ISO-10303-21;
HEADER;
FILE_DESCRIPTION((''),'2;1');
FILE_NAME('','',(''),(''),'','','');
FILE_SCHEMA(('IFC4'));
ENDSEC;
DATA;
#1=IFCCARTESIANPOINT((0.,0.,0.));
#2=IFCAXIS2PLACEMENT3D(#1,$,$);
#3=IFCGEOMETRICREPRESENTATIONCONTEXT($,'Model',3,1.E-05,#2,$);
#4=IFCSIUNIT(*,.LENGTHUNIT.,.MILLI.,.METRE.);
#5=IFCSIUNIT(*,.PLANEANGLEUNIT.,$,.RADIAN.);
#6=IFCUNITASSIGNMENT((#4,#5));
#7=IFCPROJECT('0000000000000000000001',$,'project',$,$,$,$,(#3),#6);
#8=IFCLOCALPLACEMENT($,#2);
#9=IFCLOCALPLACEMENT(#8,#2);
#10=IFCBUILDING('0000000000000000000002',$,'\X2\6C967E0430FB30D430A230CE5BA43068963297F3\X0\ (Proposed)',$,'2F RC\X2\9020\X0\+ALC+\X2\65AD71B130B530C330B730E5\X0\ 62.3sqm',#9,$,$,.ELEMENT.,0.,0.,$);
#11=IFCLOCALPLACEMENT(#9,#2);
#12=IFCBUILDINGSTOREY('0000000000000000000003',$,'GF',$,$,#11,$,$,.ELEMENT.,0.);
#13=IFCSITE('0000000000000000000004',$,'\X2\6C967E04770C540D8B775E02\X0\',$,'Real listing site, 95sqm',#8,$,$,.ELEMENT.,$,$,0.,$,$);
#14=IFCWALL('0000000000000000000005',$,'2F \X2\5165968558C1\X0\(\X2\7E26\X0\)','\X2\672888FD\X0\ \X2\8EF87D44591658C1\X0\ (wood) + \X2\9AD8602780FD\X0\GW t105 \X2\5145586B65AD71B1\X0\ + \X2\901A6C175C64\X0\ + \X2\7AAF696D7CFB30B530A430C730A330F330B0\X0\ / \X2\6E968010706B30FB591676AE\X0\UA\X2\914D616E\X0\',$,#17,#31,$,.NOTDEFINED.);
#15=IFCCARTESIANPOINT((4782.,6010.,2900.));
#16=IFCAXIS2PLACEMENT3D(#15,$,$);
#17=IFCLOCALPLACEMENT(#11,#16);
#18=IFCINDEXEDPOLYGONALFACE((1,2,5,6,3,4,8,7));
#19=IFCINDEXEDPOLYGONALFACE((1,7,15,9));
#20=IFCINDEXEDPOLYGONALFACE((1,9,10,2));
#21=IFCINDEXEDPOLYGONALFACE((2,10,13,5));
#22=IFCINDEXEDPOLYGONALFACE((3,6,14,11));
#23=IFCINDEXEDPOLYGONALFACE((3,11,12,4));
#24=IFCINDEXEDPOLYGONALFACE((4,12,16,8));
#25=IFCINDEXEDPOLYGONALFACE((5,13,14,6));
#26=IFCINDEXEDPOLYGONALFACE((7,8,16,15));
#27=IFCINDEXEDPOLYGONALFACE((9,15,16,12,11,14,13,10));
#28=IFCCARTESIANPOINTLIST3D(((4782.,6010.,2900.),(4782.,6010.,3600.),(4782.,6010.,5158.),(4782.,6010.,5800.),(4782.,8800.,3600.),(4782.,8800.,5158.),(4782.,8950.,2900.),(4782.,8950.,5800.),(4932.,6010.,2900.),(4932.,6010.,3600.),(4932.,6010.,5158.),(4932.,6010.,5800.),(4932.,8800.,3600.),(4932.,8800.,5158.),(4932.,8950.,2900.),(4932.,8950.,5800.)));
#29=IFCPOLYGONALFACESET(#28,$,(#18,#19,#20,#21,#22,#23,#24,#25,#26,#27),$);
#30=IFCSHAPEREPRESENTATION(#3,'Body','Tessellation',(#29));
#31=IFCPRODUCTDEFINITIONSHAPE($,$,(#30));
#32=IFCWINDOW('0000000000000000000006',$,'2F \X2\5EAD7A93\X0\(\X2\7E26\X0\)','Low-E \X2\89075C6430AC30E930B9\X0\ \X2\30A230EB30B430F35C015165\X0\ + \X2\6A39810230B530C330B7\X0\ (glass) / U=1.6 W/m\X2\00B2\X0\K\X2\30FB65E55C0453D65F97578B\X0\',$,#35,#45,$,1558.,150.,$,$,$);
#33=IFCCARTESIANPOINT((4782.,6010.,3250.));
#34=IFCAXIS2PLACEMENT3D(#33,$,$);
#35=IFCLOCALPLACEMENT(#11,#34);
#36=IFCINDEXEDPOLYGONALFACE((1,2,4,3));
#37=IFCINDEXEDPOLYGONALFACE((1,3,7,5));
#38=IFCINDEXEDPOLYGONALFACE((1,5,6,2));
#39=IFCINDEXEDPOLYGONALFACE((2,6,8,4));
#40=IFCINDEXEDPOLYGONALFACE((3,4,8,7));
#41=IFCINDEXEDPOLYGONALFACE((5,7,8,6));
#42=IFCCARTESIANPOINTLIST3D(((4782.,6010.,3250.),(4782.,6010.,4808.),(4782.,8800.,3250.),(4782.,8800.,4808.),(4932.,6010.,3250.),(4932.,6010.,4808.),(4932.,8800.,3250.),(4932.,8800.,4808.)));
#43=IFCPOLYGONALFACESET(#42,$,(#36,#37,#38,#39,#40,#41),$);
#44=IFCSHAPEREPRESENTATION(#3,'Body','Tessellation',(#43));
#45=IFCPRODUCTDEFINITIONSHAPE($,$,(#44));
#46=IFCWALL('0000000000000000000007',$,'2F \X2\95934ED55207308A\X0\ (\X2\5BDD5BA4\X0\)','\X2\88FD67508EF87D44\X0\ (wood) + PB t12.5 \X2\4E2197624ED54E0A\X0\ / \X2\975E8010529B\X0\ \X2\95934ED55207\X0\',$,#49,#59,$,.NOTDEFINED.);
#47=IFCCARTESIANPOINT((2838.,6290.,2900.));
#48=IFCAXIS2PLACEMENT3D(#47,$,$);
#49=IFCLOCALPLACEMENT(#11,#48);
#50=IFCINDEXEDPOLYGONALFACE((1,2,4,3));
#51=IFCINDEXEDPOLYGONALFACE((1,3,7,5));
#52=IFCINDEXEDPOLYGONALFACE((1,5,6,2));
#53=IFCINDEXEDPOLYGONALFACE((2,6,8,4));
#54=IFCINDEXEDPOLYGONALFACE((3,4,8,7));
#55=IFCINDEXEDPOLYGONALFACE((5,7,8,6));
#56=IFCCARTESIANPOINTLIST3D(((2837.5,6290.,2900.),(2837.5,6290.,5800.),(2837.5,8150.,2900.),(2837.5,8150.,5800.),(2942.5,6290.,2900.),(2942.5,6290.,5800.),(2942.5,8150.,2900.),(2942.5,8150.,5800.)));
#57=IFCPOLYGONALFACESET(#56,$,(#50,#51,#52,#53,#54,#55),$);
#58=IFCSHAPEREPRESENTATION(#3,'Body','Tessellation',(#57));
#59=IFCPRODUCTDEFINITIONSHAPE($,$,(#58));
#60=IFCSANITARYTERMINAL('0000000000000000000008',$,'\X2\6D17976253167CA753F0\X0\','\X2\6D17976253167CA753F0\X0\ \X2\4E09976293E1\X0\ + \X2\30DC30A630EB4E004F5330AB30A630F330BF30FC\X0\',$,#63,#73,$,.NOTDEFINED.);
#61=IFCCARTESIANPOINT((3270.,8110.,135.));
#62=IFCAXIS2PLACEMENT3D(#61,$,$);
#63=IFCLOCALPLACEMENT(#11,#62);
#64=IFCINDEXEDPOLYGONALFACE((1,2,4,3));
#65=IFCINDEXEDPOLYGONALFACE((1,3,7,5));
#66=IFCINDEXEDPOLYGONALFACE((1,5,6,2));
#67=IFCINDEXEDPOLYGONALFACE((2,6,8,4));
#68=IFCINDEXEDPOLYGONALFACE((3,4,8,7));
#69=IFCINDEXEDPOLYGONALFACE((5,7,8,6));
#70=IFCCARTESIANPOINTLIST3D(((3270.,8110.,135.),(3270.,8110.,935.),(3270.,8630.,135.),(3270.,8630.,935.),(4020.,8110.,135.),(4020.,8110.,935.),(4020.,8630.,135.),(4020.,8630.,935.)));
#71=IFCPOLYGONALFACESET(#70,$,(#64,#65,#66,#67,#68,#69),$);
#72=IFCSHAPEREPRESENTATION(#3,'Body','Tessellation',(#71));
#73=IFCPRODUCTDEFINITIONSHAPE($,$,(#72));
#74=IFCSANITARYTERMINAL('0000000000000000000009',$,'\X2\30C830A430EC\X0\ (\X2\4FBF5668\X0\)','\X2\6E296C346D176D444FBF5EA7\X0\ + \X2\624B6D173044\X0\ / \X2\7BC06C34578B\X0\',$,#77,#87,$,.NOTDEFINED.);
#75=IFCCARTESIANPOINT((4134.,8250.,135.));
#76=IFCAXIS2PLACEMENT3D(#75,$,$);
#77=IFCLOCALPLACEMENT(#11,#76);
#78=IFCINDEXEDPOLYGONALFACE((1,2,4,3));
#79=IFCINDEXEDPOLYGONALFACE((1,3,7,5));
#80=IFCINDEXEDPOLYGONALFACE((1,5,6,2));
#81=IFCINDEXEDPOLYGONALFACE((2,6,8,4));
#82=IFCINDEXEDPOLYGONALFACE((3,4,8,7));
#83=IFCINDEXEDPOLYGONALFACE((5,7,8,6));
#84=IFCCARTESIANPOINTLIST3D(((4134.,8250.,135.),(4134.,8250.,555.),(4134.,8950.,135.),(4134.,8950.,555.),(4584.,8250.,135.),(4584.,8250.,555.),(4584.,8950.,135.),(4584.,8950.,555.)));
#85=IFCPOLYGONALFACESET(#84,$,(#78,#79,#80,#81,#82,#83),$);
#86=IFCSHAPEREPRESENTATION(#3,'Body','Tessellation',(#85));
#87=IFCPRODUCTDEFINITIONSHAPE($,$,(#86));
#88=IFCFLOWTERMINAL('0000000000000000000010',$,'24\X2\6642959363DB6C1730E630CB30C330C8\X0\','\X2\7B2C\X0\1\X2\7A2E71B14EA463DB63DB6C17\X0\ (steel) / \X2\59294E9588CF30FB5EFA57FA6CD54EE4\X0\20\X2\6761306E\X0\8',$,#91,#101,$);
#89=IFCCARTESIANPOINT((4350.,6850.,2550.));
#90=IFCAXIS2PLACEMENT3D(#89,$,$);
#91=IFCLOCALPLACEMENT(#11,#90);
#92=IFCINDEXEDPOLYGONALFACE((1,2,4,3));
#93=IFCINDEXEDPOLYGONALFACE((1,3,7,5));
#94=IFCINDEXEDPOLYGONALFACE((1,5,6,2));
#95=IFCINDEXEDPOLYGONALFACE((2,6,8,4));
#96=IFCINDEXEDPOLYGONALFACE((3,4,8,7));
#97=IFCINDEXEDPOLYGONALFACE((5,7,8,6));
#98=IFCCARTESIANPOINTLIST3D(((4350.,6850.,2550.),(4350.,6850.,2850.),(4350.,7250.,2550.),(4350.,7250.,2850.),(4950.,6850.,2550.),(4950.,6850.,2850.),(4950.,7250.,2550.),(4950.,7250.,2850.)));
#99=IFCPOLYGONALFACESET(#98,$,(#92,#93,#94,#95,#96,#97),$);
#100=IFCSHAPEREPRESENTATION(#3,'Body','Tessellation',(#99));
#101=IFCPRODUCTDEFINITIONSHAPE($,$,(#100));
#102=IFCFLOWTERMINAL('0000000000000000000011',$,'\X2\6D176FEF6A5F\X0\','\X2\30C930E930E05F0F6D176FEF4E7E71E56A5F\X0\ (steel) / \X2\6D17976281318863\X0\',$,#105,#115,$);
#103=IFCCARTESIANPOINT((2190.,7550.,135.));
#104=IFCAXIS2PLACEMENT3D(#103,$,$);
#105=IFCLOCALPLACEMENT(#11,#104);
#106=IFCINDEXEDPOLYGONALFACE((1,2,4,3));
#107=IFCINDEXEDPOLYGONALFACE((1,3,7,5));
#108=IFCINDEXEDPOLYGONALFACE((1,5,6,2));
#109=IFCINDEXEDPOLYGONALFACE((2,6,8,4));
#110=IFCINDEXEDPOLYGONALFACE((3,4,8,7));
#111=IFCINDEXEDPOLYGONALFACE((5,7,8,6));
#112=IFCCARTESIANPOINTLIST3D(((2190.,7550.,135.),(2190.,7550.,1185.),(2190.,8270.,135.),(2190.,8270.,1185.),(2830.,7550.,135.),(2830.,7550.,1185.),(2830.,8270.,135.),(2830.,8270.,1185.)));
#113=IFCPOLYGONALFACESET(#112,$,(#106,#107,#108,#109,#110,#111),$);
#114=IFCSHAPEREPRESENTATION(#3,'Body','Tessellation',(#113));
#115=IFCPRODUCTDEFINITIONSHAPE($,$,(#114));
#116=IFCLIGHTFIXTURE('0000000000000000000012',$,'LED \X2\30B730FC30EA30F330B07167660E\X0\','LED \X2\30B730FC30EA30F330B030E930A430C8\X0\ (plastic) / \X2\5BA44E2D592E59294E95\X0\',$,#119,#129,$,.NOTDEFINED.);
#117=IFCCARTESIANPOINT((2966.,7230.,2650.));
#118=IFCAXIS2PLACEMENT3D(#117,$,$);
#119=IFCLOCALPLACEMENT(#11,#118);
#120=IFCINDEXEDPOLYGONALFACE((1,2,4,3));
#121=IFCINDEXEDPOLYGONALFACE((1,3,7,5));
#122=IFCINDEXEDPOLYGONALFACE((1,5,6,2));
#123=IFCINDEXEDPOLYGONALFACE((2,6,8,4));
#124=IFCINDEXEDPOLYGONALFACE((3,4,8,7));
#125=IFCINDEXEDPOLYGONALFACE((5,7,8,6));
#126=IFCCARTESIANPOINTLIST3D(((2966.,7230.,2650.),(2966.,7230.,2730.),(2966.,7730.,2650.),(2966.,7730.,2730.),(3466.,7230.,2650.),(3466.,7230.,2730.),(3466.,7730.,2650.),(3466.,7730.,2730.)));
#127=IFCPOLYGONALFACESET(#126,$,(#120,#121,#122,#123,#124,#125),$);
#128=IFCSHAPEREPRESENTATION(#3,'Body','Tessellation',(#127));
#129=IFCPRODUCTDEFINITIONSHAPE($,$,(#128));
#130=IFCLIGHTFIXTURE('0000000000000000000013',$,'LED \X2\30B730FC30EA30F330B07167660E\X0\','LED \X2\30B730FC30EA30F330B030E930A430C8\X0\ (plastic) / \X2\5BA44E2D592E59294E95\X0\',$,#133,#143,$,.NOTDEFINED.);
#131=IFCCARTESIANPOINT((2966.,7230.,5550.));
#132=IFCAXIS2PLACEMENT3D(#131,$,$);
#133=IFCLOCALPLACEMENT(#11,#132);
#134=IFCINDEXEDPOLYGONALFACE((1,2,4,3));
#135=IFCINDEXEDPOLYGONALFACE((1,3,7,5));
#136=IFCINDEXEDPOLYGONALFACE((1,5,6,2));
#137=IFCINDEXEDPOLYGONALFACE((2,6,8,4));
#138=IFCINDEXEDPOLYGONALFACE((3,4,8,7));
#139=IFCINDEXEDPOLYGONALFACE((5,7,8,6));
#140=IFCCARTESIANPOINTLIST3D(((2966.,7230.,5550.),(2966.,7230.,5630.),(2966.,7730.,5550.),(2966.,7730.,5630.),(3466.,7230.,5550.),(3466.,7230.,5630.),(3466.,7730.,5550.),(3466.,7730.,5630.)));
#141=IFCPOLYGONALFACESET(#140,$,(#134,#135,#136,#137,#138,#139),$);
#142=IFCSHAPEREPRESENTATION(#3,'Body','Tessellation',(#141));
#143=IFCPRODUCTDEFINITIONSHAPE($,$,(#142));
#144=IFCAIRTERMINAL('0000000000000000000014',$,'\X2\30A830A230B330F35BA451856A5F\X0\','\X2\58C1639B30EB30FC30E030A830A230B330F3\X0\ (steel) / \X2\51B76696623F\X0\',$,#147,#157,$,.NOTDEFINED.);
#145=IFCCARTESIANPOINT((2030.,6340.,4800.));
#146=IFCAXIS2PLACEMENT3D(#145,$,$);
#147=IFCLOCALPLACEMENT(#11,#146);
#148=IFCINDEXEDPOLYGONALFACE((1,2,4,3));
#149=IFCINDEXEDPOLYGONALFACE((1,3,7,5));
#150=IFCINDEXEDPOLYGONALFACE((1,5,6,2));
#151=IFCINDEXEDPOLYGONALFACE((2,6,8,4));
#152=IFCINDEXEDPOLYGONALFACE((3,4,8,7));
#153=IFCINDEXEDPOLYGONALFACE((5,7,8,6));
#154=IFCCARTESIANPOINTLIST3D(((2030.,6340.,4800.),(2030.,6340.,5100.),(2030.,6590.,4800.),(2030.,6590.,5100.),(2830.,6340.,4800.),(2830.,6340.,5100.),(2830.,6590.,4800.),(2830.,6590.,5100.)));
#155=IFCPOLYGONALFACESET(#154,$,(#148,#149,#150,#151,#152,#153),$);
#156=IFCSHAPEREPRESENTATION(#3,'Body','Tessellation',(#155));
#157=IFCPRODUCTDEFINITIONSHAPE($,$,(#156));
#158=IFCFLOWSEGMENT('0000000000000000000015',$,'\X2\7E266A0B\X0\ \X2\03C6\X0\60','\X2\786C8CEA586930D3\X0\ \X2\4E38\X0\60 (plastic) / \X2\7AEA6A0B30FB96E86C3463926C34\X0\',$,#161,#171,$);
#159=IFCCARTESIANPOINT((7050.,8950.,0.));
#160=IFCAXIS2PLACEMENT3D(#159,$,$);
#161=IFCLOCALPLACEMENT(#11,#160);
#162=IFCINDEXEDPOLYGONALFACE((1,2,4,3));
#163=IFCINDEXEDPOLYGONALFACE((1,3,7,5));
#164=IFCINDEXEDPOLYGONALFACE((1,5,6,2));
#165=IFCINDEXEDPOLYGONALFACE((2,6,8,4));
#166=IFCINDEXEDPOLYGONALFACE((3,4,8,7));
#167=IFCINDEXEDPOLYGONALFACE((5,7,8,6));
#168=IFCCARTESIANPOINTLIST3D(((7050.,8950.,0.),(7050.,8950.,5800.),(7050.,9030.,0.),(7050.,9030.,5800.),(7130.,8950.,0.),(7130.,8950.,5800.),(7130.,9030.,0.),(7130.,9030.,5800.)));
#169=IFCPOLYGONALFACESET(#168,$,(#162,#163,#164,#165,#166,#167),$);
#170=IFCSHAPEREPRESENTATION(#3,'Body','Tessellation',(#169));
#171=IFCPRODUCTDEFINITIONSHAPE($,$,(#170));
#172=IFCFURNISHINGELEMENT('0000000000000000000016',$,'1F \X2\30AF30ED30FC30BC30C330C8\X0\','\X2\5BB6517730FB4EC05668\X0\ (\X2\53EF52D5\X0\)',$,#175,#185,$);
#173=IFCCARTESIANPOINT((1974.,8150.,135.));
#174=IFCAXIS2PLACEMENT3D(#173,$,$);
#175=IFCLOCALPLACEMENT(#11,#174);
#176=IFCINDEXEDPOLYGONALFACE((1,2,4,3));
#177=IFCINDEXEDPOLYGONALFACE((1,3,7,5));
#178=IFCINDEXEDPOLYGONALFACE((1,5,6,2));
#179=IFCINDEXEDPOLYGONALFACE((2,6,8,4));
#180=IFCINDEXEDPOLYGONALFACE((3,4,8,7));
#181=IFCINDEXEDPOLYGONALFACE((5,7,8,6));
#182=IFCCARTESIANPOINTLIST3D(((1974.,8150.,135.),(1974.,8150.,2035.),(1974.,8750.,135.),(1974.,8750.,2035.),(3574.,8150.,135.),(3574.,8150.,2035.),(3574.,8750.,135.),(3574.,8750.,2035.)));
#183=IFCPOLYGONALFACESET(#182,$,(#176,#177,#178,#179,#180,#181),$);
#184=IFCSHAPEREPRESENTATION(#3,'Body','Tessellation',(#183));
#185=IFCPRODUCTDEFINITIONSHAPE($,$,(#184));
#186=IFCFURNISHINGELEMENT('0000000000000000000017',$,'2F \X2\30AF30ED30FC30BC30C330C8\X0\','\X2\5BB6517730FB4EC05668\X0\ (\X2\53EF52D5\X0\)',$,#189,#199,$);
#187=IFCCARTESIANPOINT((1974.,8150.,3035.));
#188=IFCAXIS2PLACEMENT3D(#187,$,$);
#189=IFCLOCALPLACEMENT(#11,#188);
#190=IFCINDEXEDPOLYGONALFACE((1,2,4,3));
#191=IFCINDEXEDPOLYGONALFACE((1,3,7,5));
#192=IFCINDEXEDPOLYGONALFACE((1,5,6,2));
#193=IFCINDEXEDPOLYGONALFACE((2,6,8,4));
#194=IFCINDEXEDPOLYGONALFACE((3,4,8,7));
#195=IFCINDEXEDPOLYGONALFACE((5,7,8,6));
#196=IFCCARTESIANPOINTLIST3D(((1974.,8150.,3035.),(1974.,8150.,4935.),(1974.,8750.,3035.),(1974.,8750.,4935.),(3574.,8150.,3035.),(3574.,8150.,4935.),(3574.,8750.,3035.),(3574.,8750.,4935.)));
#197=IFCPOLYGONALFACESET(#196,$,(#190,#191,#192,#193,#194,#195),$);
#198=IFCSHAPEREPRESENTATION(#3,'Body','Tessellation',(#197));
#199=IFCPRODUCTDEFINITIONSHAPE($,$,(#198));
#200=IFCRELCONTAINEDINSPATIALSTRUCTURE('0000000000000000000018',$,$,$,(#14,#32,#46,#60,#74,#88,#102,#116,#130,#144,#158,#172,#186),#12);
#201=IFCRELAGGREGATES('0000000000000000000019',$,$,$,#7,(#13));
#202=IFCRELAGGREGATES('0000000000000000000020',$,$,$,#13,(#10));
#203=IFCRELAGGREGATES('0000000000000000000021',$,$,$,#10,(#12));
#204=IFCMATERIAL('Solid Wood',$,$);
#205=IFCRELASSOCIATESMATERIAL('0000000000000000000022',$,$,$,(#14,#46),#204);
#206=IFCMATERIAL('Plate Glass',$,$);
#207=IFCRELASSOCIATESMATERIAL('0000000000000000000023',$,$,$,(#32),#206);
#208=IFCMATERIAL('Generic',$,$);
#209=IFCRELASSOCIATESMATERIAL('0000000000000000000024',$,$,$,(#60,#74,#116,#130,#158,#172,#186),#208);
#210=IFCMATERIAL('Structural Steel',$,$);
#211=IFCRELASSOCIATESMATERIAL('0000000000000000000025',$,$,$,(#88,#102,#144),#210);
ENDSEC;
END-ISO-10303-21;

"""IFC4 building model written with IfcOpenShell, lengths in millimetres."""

from ifc_helpers import new_model, si_unit, frame, frame_2d, origin, place, context, project, spatial, rectangle, extrude, material, element, fill, save


model = new_model("IFC4")

# Units and contexts
model_context = context("Model", 3, precision=1e-05, world=origin())
ifc_project = project(units=[si_unit("LENGTHUNIT", "METRE", prefix="MILLI"), si_unit("PLANEANGLEUNIT", "RADIAN")], contexts=[model_context])

# Site, building, storey
site_placement = place(None, origin())
site = spatial("IfcSite", under=ifc_project, at=site_placement, Name="沖縄県名護市", ObjectType="Real listing site, 95sqm", CompositionType="ELEMENT", RefElevation=0.0)
building_placement = place(site_placement, origin())
building = spatial("IfcBuilding", under=site, at=building_placement, Name="沖縄・ピアノ室と防音 (Proposed)", ObjectType="2F RC造+ALC+断熱サッシュ 62.3sqm", CompositionType="ELEMENT", ElevationOfRefHeight=0.0, ElevationOfTerrain=0.0)
storey_placement = place(building_placement, origin())
storey = spatial("IfcBuildingStorey", under=building, at=storey_placement, Name="GF", CompositionType="ELEMENT", Elevation=0.0)

# Shared definitions
ifc_material_1 = material(Name="Solid Wood")

# Shared definitions
ifc_material_2 = material(Name="Plate Glass")

# Wall, opening, window
wall_1_placement = place(storey_placement, frame((4782.0, 6010.0, 2900.0)))
wall_1 = element("IfcWall", 1, at=wall_1_placement, inside=storey, material=ifc_material_1, Name="2F 入隅壁(縦)", Description="木製 軸組外壁 (wood) + 高性能GW t105 充填断熱 + 通気層 + 窯業系サイディング / 準耐火・外皮UA配慮", PredefinedType="NOTDEFINED", context=model_context, shape_type="SweptSolid", body=[
    extrude(rectangle(XDim=150.0, YDim=2940.0, at=frame_2d((75.0, 1470.0))), frame((4782.0, 6010.0, 2900.0)), (0.0, 0.0, 1.0), 2900.0),
])
opening_1_placement = place(storey_placement, frame((4782.0, 6010.0, 3250.0)))
opening_1 = element("IfcOpeningElement", 2, at=opening_1_placement, cuts=wall_1, PredefinedType="NOTDEFINED", context=model_context, shape_type="SweptSolid", body=[
    extrude(rectangle(XDim=150.0, YDim=2790.0, at=frame_2d((75.0, 1395.0))), frame((4782.0, 6010.0, 3250.0)), (0.0, 0.0, 1.0), 1558.0),
])
window_1_placement = place(storey_placement, frame((4782.0, 6010.0, 3250.0)))
window_1 = element("IfcWindow", 3, at=window_1_placement, inside=storey, material=ifc_material_2, Name="2F 庭窓(縦)", Description="Low-E 複層ガラス アルゴン封入 + 樹脂サッシ (glass) / U=1.6 W/m²K・日射取得型", OverallHeight=1558.0, OverallWidth=150.0, context=model_context, shape_type="SweptSolid", body=[
    extrude(rectangle(XDim=150.0, YDim=2790.0, at=frame_2d((75.0, 1395.0))), frame((4782.0, 6010.0, 3250.0)), (0.0, 0.0, 1.0), 1558.0),
])
fill(opening_1, window_1)

# Wall
wall_2_placement = place(storey_placement, frame((2838.0, 6290.0, 2900.0)))
element("IfcWall", 4, at=wall_2_placement, inside=storey, material=ifc_material_1, Name="2F 間仕切り (寝室)", Description="製材軸組 (wood) + PB t12.5 両面仕上 / 非耐力 間仕切", PredefinedType="NOTDEFINED", context=model_context, shape_type="SweptSolid", body=[
    extrude(rectangle(XDim=105.0, YDim=1860.0, at=frame_2d((52.0, 930.0))), frame((2838.0, 6290.0, 2900.0)), (0.0, 0.0, 1.0), 2900.0),
])

# Sanitary terminals
ifc_material_3 = material(Name="Generic")
sanitary_terminal_1_placement = place(storey_placement, frame((3270.0, 8110.0, 135.0)))
element("IfcSanitaryTerminal", 5, at=sanitary_terminal_1_placement, inside=storey, material=ifc_material_3, Name="洗面化粧台", Description="洗面化粧台 三面鏡 + ボウル一体カウンター", PredefinedType="NOTDEFINED", context=model_context, shape_type="SweptSolid", body=[
    extrude(rectangle(XDim=750.0, YDim=520.0, at=frame_2d((375.0, 260.0))), frame((3270.0, 8110.0, 135.0)), (0.0, 0.0, 1.0), 800.0),
])
sanitary_terminal_2_placement = place(storey_placement, frame((4134.0, 8250.0, 135.0)))
element("IfcSanitaryTerminal", 6, at=sanitary_terminal_2_placement, inside=storey, material=ifc_material_3, Name="トイレ (便器)", Description="温水洗浄便座 + 手洗い / 節水型", PredefinedType="NOTDEFINED", context=model_context, shape_type="SweptSolid", body=[
    extrude(rectangle(XDim=450.0, YDim=700.0, at=frame_2d((225.0, 350.0))), frame((4134.0, 8250.0, 135.0)), (0.0, 0.0, 1.0), 420.0),
])

# Flow terminals
ifc_material_4 = material(Name="Structural Steel")
flow_terminal_1_placement = place(storey_placement, frame((4350.0, 6850.0, 2550.0)))
element("IfcFlowTerminal", 7, at=flow_terminal_1_placement, inside=storey, material=ifc_material_4, Name="24時間換気ユニット", Description="第1種熱交換換気 (steel) / 天井裏・建基法令20条の8", context=model_context, shape_type="SweptSolid", body=[
    extrude(rectangle(XDim=600.0, YDim=400.0, at=frame_2d((300.0, 200.0))), frame((4350.0, 6850.0, 2550.0)), (0.0, 0.0, 1.0), 300.0),
])
flow_terminal_2_placement = place(storey_placement, frame((2190.0, 7550.0, 135.0)))
element("IfcFlowTerminal", 8, at=flow_terminal_2_placement, inside=storey, material=ifc_material_4, Name="洗濯機", Description="ドラム式洗濯乾燥機 (steel) / 洗面脱衣", context=model_context, shape_type="SweptSolid", body=[
    extrude(rectangle(XDim=640.0, YDim=720.0, at=frame_2d((320.0, 360.0))), frame((2190.0, 7550.0, 135.0)), (0.0, 0.0, 1.0), 1050.0),
])

# Light fixtures
light_fixture_1_placement = place(storey_placement, frame((2966.0, 7230.0, 2650.0)))
element("IfcLightFixture", 9, at=light_fixture_1_placement, inside=storey, material=ifc_material_3, Name="LED シーリング照明", Description="LED シーリングライト (plastic) / 室中央天井", PredefinedType="NOTDEFINED", context=model_context, shape_type="SweptSolid", body=[
    extrude(rectangle(XDim=500.0, YDim=500.0, at=frame_2d((250.0, 250.0))), frame((2966.0, 7230.0, 2650.0)), (0.0, 0.0, 1.0), 80.0),
])
light_fixture_2_placement = place(storey_placement, frame((2966.0, 7230.0, 5550.0)))
element("IfcLightFixture", 10, at=light_fixture_2_placement, inside=storey, material=ifc_material_3, Name="LED シーリング照明", Description="LED シーリングライト (plastic) / 室中央天井", PredefinedType="NOTDEFINED", context=model_context, shape_type="SweptSolid", body=[
    extrude(rectangle(XDim=500.0, YDim=500.0, at=frame_2d((250.0, 250.0))), frame((2966.0, 7230.0, 5550.0)), (0.0, 0.0, 1.0), 80.0),
])

# Air terminal
air_terminal_placement = place(storey_placement, frame((2030.0, 6340.0, 4800.0)))
element("IfcAirTerminal", 11, at=air_terminal_placement, inside=storey, material=ifc_material_4, Name="エアコン室内機", Description="壁掛ルームエアコン (steel) / 冷暖房", PredefinedType="NOTDEFINED", context=model_context, shape_type="SweptSolid", body=[
    extrude(rectangle(XDim=800.0, YDim=250.0, at=frame_2d((400.0, 125.0))), frame((2030.0, 6340.0, 4800.0)), (0.0, 0.0, 1.0), 300.0),
])

# Flow segment
flow_segment_placement = place(storey_placement, frame((7050.0, 8950.0, 0.0)))
element("IfcFlowSegment", 12, at=flow_segment_placement, inside=storey, material=ifc_material_3, Name="縦樋 φ60", Description="硬質塩ビ 丸60 (plastic) / 竪樋・雨水排水", context=model_context, shape_type="SweptSolid", body=[
    extrude(rectangle(XDim=80.0, YDim=80.0, at=frame_2d((40.0, 40.0))), frame((7050.0, 8950.0, 0.0)), (0.0, 0.0, 1.0), 5800.0),
])

# Furnishing elements
furnishing_1_placement = place(storey_placement, frame((1974.0, 8150.0, 135.0)))
element("IfcFurnishingElement", 13, at=furnishing_1_placement, inside=storey, material=ifc_material_3, Name="1F クローゼット", Description="家具・什器 (可動)", context=model_context, shape_type="SweptSolid", body=[
    extrude(rectangle(XDim=1600.0, YDim=600.0, at=frame_2d((800.0, 300.0))), frame((1974.0, 8150.0, 135.0)), (0.0, 0.0, 1.0), 1900.0),
])
furnishing_2_placement = place(storey_placement, frame((1974.0, 8150.0, 3035.0)))
element("IfcFurnishingElement", 14, at=furnishing_2_placement, inside=storey, material=ifc_material_3, Name="2F クローゼット", Description="家具・什器 (可動)", context=model_context, shape_type="SweptSolid", body=[
    extrude(rectangle(XDim=1600.0, YDim=600.0, at=frame_2d((800.0, 300.0))), frame((1974.0, 8150.0, 3035.0)), (0.0, 0.0, 1.0), 1900.0),
])

save(model, "model.ifc")
